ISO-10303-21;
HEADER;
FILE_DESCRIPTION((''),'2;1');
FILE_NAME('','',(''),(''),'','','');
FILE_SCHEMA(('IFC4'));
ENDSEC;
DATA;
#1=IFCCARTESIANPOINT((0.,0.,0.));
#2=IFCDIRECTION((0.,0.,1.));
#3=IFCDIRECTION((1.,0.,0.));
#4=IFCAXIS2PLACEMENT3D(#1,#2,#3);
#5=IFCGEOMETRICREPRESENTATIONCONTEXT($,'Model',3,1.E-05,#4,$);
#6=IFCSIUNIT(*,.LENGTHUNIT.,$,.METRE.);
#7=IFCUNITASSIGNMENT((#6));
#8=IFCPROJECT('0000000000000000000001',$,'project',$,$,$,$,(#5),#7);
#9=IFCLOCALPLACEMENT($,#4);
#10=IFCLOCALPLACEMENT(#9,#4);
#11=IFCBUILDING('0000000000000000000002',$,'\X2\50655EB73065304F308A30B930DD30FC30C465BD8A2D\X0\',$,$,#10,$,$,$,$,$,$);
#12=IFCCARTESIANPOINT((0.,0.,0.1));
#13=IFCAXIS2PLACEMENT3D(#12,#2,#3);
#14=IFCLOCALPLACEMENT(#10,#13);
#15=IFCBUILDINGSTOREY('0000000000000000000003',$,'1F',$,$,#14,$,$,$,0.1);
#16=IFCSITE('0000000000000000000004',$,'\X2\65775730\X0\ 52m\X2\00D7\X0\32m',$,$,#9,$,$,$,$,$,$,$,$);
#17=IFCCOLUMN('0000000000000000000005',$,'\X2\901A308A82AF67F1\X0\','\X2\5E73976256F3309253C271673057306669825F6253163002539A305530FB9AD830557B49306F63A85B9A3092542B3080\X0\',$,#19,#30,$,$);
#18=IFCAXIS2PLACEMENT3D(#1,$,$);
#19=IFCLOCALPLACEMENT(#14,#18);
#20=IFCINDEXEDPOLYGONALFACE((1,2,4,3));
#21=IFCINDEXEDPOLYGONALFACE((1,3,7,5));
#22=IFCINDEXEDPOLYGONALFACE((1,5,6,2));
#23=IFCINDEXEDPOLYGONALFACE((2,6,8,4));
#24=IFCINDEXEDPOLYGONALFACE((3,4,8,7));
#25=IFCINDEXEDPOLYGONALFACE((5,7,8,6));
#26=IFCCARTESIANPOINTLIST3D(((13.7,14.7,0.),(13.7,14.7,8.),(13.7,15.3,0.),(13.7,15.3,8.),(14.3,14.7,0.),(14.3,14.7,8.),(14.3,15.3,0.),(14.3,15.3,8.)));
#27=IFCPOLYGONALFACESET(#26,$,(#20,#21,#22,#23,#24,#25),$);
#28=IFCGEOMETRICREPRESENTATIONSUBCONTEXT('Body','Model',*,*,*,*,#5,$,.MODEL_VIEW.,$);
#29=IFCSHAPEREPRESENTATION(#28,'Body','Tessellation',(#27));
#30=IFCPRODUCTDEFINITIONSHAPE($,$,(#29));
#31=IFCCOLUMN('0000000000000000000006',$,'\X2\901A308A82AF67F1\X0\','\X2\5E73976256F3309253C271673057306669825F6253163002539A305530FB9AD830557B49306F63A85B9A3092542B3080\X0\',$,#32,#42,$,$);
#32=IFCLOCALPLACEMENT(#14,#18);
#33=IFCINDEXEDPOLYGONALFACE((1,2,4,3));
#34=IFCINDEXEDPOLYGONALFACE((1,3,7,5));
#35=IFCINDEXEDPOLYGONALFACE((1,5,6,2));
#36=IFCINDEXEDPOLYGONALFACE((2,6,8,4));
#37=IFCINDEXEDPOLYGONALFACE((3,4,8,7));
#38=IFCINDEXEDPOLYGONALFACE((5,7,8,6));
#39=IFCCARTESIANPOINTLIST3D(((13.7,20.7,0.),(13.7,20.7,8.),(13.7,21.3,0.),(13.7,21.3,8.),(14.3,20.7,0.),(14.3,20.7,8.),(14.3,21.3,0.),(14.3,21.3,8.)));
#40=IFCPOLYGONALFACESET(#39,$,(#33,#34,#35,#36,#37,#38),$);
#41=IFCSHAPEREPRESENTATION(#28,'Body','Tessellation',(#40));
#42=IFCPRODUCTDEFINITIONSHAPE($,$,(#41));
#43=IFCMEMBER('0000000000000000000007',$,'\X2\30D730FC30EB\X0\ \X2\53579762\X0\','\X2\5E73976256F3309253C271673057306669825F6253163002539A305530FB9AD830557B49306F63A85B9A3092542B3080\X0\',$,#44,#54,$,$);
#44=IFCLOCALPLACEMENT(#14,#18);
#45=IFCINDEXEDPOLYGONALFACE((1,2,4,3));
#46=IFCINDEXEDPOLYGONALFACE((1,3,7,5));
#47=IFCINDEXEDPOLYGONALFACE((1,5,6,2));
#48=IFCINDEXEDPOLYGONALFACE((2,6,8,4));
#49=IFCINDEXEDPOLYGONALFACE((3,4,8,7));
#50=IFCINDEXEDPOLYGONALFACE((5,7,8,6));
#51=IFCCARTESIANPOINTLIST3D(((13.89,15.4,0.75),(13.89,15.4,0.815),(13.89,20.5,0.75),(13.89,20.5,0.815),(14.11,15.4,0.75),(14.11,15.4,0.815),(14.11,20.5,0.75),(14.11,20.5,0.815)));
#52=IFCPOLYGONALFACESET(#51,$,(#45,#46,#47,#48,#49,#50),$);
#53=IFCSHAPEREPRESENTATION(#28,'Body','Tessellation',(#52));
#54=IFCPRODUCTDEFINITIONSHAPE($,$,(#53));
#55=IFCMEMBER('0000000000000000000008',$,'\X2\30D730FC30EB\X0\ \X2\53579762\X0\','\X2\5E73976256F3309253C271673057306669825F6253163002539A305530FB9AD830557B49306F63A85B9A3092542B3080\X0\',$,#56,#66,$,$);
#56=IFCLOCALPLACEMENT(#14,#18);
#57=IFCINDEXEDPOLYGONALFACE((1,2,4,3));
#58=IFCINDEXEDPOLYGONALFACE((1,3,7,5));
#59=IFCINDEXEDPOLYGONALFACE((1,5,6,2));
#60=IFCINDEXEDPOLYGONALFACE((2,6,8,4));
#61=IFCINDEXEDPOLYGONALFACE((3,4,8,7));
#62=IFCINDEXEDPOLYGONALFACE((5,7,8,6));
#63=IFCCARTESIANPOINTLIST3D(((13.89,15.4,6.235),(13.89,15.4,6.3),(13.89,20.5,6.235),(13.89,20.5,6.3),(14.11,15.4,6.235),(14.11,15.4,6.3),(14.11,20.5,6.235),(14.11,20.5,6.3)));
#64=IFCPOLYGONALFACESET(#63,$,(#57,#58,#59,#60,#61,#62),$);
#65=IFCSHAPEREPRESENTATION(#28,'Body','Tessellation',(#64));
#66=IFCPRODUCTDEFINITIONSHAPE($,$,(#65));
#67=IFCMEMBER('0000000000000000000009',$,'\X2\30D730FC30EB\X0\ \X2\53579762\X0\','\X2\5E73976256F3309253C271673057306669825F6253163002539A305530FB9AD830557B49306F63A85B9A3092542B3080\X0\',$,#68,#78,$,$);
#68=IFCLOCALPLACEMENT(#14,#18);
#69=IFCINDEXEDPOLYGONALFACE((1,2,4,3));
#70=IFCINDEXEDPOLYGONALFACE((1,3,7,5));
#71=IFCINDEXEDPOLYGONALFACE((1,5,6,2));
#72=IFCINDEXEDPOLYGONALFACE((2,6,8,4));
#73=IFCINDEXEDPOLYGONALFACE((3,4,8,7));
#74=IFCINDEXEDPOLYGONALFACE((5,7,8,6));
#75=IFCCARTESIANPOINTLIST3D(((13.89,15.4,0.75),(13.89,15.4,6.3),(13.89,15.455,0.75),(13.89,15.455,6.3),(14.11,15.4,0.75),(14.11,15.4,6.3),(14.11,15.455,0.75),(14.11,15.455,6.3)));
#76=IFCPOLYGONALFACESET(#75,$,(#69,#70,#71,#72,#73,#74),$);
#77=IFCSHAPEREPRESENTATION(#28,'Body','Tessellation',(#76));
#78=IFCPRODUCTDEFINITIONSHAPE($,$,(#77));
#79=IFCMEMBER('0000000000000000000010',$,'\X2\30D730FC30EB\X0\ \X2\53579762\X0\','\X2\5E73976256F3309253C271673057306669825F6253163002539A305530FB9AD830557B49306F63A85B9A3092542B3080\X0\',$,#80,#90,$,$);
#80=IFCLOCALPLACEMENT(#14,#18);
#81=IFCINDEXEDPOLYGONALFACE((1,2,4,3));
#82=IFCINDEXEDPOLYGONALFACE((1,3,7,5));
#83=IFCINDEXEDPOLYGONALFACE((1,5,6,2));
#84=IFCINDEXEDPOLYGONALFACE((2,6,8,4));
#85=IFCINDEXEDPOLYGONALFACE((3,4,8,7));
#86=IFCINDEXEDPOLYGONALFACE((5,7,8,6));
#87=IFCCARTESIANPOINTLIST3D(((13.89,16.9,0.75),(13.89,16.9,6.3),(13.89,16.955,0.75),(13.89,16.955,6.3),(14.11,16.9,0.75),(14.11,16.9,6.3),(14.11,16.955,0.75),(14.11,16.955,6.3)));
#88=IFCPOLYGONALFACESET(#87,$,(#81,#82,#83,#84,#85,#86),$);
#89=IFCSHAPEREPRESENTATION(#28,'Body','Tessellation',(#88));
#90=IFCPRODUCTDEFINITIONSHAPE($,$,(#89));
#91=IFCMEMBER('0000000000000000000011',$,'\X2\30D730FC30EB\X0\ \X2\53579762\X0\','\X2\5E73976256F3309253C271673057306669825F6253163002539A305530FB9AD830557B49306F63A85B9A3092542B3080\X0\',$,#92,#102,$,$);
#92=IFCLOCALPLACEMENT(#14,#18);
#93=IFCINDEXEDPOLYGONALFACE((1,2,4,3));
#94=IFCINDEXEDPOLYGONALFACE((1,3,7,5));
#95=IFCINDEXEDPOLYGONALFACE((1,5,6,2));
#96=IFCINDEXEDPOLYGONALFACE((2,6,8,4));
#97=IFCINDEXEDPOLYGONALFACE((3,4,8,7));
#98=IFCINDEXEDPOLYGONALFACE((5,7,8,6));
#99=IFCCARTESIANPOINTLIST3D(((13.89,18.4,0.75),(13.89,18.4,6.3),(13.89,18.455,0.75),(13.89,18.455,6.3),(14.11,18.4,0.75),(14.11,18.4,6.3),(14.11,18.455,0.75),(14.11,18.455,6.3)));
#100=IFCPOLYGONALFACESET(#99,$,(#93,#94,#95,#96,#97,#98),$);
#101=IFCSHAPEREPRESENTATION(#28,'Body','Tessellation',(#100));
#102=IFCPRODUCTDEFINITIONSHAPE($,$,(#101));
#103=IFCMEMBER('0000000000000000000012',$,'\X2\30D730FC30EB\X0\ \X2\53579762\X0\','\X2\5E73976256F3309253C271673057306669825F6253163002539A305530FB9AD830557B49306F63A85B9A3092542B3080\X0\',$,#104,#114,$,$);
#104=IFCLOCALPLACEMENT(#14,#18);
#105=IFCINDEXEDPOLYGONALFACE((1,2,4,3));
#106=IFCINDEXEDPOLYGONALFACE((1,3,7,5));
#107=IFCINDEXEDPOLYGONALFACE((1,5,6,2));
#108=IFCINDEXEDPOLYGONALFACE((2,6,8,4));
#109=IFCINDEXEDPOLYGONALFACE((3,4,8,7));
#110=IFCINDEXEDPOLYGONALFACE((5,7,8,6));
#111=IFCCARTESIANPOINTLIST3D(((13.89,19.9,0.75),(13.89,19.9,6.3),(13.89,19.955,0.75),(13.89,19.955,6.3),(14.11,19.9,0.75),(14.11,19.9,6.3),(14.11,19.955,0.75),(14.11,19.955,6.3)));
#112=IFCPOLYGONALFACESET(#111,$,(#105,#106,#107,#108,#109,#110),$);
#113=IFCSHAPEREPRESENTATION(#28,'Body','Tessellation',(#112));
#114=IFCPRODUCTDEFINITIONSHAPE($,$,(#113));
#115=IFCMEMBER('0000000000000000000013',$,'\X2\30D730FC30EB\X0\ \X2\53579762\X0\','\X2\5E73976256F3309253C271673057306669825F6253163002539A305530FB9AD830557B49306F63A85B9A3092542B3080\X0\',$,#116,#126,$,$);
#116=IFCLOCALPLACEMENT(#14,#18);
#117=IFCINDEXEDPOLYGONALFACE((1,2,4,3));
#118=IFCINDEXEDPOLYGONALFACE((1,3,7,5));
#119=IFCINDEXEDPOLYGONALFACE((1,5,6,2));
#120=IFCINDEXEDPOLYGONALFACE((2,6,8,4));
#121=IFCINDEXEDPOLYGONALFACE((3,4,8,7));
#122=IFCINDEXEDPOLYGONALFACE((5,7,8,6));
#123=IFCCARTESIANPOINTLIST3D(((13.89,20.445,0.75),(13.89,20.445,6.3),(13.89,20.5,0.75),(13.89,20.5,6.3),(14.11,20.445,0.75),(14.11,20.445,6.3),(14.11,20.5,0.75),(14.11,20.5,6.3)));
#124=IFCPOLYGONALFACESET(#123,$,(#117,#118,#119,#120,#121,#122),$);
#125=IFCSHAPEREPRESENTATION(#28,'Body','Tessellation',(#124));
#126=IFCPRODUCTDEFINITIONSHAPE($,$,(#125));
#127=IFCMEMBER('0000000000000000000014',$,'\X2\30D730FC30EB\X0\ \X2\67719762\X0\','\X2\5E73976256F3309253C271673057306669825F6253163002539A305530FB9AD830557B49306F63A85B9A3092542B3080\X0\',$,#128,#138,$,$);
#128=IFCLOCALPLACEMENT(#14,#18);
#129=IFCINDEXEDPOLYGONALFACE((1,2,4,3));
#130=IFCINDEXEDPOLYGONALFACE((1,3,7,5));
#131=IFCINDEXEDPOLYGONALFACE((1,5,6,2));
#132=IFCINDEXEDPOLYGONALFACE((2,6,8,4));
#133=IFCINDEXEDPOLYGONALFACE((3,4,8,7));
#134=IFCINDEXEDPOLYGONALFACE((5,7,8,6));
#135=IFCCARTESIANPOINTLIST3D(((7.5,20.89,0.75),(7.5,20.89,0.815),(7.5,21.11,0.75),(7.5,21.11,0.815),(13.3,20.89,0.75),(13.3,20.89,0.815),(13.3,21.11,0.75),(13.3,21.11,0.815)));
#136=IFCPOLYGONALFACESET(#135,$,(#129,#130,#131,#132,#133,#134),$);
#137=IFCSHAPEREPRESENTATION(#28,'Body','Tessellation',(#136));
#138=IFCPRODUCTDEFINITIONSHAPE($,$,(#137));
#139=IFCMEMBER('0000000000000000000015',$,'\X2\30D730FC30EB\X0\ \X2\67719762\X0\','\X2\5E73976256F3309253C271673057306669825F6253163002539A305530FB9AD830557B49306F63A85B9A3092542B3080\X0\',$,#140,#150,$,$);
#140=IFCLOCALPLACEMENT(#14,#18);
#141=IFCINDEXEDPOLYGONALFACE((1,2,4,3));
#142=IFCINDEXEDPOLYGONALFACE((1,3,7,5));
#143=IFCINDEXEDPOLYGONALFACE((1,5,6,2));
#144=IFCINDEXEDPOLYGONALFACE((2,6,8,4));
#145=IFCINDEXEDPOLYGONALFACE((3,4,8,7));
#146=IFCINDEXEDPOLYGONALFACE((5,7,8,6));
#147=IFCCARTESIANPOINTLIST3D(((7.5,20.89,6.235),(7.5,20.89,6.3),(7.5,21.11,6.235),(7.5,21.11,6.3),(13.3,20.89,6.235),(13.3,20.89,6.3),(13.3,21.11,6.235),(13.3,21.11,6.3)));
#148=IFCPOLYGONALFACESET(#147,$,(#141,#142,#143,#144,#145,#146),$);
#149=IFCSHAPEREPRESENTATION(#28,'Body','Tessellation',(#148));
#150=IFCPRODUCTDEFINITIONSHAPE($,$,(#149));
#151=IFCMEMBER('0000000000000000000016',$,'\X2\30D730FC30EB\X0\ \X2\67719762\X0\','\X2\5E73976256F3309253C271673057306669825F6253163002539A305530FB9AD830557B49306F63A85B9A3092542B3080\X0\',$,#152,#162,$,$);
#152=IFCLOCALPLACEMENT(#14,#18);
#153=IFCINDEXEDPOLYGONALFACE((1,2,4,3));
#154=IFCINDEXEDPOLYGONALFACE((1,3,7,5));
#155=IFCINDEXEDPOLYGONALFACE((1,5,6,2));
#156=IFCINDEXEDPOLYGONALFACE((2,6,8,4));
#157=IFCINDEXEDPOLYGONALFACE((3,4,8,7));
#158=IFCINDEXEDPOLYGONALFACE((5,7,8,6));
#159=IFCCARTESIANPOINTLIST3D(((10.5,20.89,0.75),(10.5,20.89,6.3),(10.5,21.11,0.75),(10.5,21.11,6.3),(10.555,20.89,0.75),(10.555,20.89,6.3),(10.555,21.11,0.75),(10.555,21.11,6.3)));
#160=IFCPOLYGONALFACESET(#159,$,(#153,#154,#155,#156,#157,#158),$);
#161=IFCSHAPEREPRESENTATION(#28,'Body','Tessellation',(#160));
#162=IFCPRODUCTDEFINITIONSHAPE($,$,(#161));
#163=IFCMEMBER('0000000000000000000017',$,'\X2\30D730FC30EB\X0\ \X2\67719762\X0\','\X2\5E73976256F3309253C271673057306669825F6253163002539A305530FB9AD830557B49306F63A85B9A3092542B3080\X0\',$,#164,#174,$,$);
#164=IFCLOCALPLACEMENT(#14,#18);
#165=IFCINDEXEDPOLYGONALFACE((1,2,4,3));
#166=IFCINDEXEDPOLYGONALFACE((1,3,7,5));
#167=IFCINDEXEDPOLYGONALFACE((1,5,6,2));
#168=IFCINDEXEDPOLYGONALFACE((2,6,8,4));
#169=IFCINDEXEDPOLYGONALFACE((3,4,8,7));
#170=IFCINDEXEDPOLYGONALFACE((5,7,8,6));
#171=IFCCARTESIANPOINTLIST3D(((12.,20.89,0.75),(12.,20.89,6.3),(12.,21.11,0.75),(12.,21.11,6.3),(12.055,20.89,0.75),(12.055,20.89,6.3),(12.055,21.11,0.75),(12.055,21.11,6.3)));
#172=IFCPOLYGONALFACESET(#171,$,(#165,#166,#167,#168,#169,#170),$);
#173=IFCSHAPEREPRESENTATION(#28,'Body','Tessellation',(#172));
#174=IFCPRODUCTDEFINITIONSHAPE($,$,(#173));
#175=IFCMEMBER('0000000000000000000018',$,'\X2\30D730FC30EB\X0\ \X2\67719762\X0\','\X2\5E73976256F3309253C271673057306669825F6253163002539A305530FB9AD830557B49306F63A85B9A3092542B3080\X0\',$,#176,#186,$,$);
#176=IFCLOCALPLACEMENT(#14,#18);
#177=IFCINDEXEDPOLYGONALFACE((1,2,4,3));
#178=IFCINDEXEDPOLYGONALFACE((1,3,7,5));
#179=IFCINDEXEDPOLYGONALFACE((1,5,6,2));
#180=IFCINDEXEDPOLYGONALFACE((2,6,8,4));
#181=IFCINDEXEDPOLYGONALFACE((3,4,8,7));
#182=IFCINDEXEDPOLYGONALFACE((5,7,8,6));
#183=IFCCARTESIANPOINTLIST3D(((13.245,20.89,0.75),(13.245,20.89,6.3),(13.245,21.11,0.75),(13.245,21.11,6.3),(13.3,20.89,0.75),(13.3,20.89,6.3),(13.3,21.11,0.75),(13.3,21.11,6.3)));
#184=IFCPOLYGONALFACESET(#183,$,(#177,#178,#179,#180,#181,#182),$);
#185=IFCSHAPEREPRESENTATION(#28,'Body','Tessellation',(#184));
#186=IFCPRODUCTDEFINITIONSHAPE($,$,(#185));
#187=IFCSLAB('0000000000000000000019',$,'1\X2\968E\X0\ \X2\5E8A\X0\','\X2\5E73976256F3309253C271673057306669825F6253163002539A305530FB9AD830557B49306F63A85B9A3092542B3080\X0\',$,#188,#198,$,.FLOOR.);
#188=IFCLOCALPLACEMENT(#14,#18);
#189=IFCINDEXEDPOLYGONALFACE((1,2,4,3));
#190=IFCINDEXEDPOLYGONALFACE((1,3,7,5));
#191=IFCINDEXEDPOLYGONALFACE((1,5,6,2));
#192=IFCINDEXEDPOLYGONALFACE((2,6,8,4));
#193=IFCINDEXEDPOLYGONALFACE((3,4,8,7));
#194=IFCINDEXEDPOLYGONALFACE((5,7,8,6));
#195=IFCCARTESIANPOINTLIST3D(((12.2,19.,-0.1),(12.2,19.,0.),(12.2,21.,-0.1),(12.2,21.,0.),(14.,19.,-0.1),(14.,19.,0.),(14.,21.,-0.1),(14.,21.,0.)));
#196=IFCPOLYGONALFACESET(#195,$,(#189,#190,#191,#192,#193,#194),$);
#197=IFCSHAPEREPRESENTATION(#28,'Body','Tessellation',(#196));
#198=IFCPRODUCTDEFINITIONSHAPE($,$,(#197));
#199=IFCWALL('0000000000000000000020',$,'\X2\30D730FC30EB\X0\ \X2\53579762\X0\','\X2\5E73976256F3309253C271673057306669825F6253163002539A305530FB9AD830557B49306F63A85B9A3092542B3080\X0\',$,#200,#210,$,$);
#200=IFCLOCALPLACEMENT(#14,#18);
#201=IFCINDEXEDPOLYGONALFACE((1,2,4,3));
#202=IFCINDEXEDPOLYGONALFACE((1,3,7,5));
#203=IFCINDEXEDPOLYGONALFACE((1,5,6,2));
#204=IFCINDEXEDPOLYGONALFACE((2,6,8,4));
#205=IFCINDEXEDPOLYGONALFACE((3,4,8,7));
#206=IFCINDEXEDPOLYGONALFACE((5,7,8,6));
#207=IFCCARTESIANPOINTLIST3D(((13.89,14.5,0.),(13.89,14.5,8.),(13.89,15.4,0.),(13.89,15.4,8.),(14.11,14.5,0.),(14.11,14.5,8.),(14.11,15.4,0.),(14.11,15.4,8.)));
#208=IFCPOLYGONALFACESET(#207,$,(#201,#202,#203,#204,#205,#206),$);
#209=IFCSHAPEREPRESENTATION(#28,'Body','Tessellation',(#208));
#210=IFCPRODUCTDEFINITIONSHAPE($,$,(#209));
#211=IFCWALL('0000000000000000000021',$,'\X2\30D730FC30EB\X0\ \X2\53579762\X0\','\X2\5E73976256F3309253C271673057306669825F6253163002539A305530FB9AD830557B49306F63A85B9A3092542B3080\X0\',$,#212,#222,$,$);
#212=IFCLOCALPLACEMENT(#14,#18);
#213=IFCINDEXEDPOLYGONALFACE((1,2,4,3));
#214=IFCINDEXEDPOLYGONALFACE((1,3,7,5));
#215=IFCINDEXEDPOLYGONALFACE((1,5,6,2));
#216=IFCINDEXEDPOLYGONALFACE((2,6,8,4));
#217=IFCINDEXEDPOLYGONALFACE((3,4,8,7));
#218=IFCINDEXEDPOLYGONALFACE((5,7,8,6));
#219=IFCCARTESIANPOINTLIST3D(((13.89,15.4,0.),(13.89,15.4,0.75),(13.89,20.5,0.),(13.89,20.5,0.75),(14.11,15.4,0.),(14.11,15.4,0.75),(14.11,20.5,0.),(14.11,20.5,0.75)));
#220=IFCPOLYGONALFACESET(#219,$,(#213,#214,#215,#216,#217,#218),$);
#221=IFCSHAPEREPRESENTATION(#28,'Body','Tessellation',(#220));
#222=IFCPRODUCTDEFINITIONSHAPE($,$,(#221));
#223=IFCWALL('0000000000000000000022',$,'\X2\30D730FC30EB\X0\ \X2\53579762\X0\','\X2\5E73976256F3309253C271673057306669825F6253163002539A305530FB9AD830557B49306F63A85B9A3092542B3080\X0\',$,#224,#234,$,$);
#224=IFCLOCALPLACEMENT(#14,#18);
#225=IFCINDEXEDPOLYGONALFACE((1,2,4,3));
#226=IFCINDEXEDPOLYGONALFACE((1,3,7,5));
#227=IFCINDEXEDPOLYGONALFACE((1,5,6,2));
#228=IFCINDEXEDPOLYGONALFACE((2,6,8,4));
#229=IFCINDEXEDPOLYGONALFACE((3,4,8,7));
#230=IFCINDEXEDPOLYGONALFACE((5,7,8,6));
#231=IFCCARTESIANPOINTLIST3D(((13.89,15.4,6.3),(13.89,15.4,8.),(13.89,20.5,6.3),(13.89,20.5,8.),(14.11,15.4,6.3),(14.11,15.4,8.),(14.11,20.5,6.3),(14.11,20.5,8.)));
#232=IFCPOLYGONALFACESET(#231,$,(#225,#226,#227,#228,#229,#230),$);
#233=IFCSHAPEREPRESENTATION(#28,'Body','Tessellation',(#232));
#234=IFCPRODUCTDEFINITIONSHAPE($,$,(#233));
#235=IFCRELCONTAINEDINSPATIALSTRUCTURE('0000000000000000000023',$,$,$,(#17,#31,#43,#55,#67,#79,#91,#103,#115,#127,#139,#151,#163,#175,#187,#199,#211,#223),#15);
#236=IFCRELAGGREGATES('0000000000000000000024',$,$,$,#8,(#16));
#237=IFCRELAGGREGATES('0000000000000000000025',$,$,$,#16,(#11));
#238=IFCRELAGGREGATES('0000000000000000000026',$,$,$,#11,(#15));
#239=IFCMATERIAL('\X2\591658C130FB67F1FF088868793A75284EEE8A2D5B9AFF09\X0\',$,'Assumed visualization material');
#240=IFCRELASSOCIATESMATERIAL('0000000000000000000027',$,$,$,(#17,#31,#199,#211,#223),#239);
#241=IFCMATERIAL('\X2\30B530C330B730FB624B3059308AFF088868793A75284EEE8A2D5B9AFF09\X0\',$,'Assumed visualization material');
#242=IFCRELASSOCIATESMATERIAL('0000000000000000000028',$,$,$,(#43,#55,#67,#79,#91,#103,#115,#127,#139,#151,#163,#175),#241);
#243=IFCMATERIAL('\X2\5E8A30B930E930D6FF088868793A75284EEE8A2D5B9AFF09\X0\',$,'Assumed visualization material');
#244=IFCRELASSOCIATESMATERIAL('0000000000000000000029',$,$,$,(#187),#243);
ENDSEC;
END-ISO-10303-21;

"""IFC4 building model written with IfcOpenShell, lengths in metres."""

from ifc_helpers import new_model, si_unit, frame, origin_with_axes, place, context, subcontext, project, spatial, rectangle, extrude, material, element, save


model = new_model("IFC4")

# Units and contexts
model_context = context("Model", 3, precision=1e-05, world=origin_with_axes())
body_context = subcontext(model_context, "Body", "Model", "MODEL_VIEW")
ifc_project = project(units=[si_unit("LENGTHUNIT", "METRE")], contexts=[model_context])

# Site, building, storey
site_placement = place(None, origin_with_axes())
site = spatial("IfcSite", under=ifc_project, at=site_placement, Name="敷地 52m×32m")
building_placement = place(site_placement, origin_with_axes())
building = spatial("IfcBuilding", under=site, at=building_placement, Name="健康づくりスポーツ施設")
storey_placement = place(building_placement, frame((0.0, 0.0, 0.1), z_axis=(0.0, 0.0, 1.0), x_axis=(1.0, 0.0, 0.0)))
storey = spatial("IfcBuildingStorey", under=building, at=storey_placement, Name="1F", Elevation=0.1)

# Columns
ifc_material_1 = material(Name="外壁・柱（表示用仮設定）", Category="Assumed visualization material")
for number, where, z_axis, x_axis, name in (
    (1, (14.0, 15.0, 0.0), (0.0, 0.0, 1.0), (1.0, 0.0, 0.0), "通り芯柱"),
    (2, (14.0, 21.0, 0.0), (0.0, 0.0, 1.0), (1.0, 0.0, 0.0), "通り芯柱"),
):
    element("IfcColumn", number, at=place(storey_placement, frame(where, z_axis=z_axis, x_axis=x_axis)), inside=storey, material=ifc_material_1, Name=name, Description="平面図を参照して概形化。厚さ・高さ等は推定を含む", context=body_context, shape_type="SweptSolid", body=[
        extrude(rectangle(XDim=0.6, YDim=0.6), origin_with_axes(), (0.0, 0.0, 1.0), 8.0),
    ])

# Members
ifc_material_2 = material(Name="サッシ・手すり（表示用仮設定）", Category="Assumed visualization material")
member_1_placement = place(storey_placement, frame((14.0, 17.95, 0.75), z_axis=(0.0, 0.0, 1.0), x_axis=(1.0, 0.0, 0.0)))
element("IfcMember", 3, at=member_1_placement, inside=storey, material=ifc_material_2, Name="プール 南面", Description="平面図を参照して概形化。厚さ・高さ等は推定を含む", context=body_context, shape_type="SweptSolid", body=[
    extrude(rectangle(XDim=0.22, YDim=5.1), origin_with_axes(), (0.0, 0.0, 1.0), 0.065),
])
member_2_placement = place(storey_placement, frame((14.0, 17.95, 6.235), z_axis=(0.0, 0.0, 1.0), x_axis=(1.0, 0.0, 0.0)))
element("IfcMember", 4, at=member_2_placement, inside=storey, material=ifc_material_2, Name="プール 南面", Description="平面図を参照して概形化。厚さ・高さ等は推定を含む", context=body_context, shape_type="SweptSolid", body=[
    extrude(rectangle(XDim=0.22, YDim=5.1), origin_with_axes(), (0.0, 0.0, 1.0), 0.065),
])
for number, where, z_axis, x_axis, name in (
    (5, (14.0, 15.4275, 0.75), (0.0, 0.0, 1.0), (1.0, 0.0, 0.0), "プール 南面"),
    (6, (14.0, 16.9275, 0.75), (0.0, 0.0, 1.0), (1.0, 0.0, 0.0), "プール 南面"),
    (7, (14.0, 18.4275, 0.75), (0.0, 0.0, 1.0), (1.0, 0.0, 0.0), "プール 南面"),
    (8, (14.0, 19.9275, 0.75), (0.0, 0.0, 1.0), (1.0, 0.0, 0.0), "プール 南面"),
    (9, (14.0, 20.4725, 0.75), (0.0, 0.0, 1.0), (1.0, 0.0, 0.0), "プール 南面"),
):
    element("IfcMember", number, at=place(storey_placement, frame(where, z_axis=z_axis, x_axis=x_axis)), inside=storey, material=ifc_material_2, Name=name, Description="平面図を参照して概形化。厚さ・高さ等は推定を含む", context=body_context, shape_type="SweptSolid", body=[
        extrude(rectangle(XDim=0.22, YDim=0.055), origin_with_axes(), (0.0, 0.0, 1.0), 5.55),
    ])
member_3_placement = place(storey_placement, frame((10.4, 21.0, 0.75), z_axis=(0.0, 0.0, 1.0), x_axis=(1.0, 0.0, 0.0)))
element("IfcMember", 10, at=member_3_placement, inside=storey, material=ifc_material_2, Name="プール 東面", Description="平面図を参照して概形化。厚さ・高さ等は推定を含む", context=body_context, shape_type="SweptSolid", body=[
    extrude(rectangle(XDim=5.8, YDim=0.22), origin_with_axes(), (0.0, 0.0, 1.0), 0.065),
])
member_4_placement = place(storey_placement, frame((10.4, 21.0, 6.235), z_axis=(0.0, 0.0, 1.0), x_axis=(1.0, 0.0, 0.0)))
element("IfcMember", 11, at=member_4_placement, inside=storey, material=ifc_material_2, Name="プール 東面", Description="平面図を参照して概形化。厚さ・高さ等は推定を含む", context=body_context, shape_type="SweptSolid", body=[
    extrude(rectangle(XDim=5.8, YDim=0.22), origin_with_axes(), (0.0, 0.0, 1.0), 0.065),
])
for number, where, z_axis, x_axis, name in (
    (12, (10.5275, 21.0, 0.75), (0.0, 0.0, 1.0), (1.0, 0.0, 0.0), "プール 東面"),
    (13, (12.0275, 21.0, 0.75), (0.0, 0.0, 1.0), (1.0, 0.0, 0.0), "プール 東面"),
    (14, (13.2725, 21.0, 0.75), (0.0, 0.0, 1.0), (1.0, 0.0, 0.0), "プール 東面"),
):
    element("IfcMember", number, at=place(storey_placement, frame(where, z_axis=z_axis, x_axis=x_axis)), inside=storey, material=ifc_material_2, Name=name, Description="平面図を参照して概形化。厚さ・高さ等は推定を含む", context=body_context, shape_type="SweptSolid", body=[
        extrude(rectangle(XDim=0.055, YDim=0.22), origin_with_axes(), (0.0, 0.0, 1.0), 5.55),
    ])

# Slab
ifc_material_3 = material(Name="床スラブ（表示用仮設定）", Category="Assumed visualization material")
slab_placement = place(storey_placement, frame((13.1, 20.0, -0.1), z_axis=(0.0, 0.0, 1.0), x_axis=(1.0, 0.0, 0.0)))
element("IfcSlab", 15, at=slab_placement, inside=storey, material=ifc_material_3, Name="1階 床", Description="平面図を参照して概形化。厚さ・高さ等は推定を含む", PredefinedType="FLOOR", context=body_context, shape_type="SweptSolid", body=[
    extrude(rectangle(XDim=1.8, YDim=2.0), origin_with_axes(), (0.0, 0.0, 1.0), 0.1),
])

# Walls
wall_1_placement = place(storey_placement, frame((14.0, 14.95, 0.0), z_axis=(0.0, 0.0, 1.0), x_axis=(1.0, 0.0, 0.0)))
element("IfcWall", 16, at=wall_1_placement, inside=storey, material=ifc_material_1, Name="プール 南面", Description="平面図を参照して概形化。厚さ・高さ等は推定を含む", context=body_context, shape_type="SweptSolid", body=[
    extrude(rectangle(XDim=0.22, YDim=0.9), origin_with_axes(), (0.0, 0.0, 1.0), 8.0),
])
wall_2_placement = place(storey_placement, frame((14.0, 17.95, 0.0), z_axis=(0.0, 0.0, 1.0), x_axis=(1.0, 0.0, 0.0)))
element("IfcWall", 17, at=wall_2_placement, inside=storey, material=ifc_material_1, Name="プール 南面", Description="平面図を参照して概形化。厚さ・高さ等は推定を含む", context=body_context, shape_type="SweptSolid", body=[
    extrude(rectangle(XDim=0.22, YDim=5.1), origin_with_axes(), (0.0, 0.0, 1.0), 0.75),
])
wall_3_placement = place(storey_placement, frame((14.0, 17.95, 6.3), z_axis=(0.0, 0.0, 1.0), x_axis=(1.0, 0.0, 0.0)))
element("IfcWall", 18, at=wall_3_placement, inside=storey, material=ifc_material_1, Name="プール 南面", Description="平面図を参照して概形化。厚さ・高さ等は推定を含む", context=body_context, shape_type="SweptSolid", body=[
    extrude(rectangle(XDim=0.22, YDim=5.1), origin_with_axes(), (0.0, 0.0, 1.0), 1.7),
])

save(model, "model.ifc")
